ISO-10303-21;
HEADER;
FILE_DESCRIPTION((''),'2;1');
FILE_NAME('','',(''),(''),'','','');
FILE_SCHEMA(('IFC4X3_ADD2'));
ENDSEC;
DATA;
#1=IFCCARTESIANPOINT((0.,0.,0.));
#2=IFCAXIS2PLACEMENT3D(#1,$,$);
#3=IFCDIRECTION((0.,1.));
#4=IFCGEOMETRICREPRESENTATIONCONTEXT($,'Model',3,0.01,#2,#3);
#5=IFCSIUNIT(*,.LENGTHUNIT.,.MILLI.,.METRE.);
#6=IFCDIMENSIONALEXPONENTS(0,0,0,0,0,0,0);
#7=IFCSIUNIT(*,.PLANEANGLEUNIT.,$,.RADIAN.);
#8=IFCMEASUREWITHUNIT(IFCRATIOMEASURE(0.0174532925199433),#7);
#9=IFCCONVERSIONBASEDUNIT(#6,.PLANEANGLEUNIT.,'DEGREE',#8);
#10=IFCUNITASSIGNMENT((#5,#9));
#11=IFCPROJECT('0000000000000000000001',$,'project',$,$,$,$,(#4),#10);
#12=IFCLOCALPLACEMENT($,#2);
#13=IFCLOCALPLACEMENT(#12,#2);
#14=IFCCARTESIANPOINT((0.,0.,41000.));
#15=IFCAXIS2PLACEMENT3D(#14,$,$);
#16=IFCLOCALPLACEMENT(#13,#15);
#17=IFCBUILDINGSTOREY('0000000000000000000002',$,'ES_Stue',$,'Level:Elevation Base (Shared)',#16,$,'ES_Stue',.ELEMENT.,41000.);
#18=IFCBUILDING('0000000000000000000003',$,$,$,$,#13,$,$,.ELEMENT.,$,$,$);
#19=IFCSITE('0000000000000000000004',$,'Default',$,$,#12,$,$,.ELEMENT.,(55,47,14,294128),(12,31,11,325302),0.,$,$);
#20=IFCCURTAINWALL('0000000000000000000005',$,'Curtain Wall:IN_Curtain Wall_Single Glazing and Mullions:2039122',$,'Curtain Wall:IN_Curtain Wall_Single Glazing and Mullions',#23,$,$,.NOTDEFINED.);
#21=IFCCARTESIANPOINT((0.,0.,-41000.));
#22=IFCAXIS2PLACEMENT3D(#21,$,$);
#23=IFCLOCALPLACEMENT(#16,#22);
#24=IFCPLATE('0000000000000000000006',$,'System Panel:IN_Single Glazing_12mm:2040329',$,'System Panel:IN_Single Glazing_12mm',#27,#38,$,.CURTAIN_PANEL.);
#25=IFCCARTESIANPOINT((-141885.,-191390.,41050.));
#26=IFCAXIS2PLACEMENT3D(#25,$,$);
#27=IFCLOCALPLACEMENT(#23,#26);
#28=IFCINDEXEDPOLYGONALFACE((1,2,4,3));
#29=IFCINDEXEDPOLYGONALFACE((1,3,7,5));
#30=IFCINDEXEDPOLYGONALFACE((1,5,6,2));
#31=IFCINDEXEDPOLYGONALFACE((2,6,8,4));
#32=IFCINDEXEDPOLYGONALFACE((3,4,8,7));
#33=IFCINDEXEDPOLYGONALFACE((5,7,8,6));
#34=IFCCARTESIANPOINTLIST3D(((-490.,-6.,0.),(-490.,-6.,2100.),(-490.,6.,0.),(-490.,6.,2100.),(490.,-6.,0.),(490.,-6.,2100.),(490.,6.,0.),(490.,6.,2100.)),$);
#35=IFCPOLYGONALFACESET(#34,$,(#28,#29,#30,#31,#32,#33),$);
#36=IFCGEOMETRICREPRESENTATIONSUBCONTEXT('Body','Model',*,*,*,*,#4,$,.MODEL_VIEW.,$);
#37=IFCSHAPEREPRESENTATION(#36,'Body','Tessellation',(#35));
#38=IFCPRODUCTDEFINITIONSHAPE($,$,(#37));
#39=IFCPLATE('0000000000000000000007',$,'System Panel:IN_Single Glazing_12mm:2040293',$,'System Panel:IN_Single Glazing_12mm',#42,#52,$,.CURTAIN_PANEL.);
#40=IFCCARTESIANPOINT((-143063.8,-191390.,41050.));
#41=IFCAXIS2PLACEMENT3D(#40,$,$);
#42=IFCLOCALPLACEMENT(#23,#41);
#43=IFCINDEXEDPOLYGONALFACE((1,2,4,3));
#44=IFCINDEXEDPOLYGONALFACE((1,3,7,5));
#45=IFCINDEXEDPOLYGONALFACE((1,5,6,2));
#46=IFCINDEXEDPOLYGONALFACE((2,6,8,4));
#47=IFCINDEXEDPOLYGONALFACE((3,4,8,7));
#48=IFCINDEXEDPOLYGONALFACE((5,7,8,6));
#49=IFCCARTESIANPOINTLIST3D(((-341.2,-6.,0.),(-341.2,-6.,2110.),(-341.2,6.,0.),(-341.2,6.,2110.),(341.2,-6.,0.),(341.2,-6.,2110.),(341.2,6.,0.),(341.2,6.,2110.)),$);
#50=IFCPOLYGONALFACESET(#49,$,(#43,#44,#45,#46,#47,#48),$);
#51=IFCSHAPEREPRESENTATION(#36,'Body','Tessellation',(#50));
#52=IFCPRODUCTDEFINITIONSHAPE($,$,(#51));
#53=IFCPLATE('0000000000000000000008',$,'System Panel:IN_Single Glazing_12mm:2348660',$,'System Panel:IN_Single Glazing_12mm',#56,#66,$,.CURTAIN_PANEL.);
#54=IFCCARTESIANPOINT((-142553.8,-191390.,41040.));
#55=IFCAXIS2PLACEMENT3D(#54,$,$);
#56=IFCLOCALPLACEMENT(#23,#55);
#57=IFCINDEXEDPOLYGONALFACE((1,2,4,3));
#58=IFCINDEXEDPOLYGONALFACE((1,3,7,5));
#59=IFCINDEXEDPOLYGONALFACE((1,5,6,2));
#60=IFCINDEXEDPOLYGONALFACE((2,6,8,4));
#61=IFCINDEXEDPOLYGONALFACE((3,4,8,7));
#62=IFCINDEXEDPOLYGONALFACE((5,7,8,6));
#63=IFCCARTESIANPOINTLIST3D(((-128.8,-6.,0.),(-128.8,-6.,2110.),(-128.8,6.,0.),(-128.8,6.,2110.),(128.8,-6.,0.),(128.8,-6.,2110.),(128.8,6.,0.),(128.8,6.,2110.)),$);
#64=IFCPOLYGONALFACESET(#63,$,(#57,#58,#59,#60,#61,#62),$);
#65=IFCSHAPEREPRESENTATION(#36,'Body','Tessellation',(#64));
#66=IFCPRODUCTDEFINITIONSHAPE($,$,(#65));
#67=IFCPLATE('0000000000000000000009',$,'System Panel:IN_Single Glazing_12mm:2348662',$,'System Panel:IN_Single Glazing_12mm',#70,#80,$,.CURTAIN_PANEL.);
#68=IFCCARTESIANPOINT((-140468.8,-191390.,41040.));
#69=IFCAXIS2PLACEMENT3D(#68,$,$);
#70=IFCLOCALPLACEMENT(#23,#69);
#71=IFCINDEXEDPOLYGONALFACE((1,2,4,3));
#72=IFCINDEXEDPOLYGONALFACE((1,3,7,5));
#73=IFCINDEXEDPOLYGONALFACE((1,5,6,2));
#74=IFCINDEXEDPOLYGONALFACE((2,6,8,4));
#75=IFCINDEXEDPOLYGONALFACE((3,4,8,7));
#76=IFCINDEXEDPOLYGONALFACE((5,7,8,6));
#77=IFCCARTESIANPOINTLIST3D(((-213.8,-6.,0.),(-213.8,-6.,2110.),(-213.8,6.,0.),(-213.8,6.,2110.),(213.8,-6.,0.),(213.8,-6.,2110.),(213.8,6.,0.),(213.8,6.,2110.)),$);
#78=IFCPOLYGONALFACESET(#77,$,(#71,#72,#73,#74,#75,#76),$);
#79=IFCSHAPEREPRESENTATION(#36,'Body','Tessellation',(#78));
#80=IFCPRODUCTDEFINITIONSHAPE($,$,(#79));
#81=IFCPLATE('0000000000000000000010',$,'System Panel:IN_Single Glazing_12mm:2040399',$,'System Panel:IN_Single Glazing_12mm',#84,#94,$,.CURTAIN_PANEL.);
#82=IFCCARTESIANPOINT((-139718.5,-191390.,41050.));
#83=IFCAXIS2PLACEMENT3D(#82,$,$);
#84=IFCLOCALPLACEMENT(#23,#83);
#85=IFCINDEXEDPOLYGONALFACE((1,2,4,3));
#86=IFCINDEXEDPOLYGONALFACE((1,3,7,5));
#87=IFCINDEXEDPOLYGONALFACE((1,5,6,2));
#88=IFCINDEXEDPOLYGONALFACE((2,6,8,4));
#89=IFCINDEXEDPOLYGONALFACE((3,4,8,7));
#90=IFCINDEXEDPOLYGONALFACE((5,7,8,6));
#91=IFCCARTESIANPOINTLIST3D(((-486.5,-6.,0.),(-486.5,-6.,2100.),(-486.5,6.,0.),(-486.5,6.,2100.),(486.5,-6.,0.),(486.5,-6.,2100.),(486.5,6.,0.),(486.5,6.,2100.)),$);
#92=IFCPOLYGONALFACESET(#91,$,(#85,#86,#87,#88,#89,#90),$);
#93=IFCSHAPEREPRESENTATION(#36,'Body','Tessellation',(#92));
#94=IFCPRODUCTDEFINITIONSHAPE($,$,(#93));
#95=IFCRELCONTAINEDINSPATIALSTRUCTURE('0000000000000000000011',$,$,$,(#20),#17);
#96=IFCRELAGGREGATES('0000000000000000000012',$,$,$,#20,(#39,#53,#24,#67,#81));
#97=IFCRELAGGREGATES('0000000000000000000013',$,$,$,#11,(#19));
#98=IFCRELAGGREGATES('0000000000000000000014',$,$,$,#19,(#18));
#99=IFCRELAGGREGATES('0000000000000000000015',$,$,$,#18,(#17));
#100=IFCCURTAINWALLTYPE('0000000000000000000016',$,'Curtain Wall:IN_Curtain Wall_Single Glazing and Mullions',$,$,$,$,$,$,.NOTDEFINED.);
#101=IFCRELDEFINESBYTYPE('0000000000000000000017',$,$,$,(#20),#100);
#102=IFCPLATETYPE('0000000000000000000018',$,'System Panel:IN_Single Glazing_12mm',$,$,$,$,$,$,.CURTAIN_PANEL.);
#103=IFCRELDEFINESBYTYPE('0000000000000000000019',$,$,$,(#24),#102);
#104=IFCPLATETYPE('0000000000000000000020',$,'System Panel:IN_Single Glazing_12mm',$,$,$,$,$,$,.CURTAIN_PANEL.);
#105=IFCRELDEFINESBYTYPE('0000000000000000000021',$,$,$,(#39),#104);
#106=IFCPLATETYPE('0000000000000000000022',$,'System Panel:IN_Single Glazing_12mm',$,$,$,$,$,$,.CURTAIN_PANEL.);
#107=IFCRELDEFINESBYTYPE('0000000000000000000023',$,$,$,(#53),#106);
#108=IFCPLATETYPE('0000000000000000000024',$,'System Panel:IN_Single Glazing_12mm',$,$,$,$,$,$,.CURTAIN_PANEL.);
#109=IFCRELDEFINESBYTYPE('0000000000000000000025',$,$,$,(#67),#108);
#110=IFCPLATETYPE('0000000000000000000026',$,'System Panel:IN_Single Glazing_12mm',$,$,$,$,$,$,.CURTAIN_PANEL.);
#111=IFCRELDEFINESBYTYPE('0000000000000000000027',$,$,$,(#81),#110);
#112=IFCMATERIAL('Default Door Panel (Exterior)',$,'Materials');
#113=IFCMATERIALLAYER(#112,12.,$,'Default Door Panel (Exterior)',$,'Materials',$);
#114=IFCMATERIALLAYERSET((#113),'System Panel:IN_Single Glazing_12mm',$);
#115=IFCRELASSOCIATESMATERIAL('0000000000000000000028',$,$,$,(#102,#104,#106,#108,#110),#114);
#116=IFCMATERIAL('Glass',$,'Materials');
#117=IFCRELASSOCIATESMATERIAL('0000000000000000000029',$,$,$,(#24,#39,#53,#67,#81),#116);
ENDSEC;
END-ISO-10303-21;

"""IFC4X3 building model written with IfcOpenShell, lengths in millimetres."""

from ifc_helpers import new_model, entity, si_unit, converted_unit, direction, frame, origin, origin_2d_with_axis, place, context, subcontext, project, spatial, rectangle, extrude, source, transform, mapped, material, layer, layer_set, type_object, type_shapes, element, aggregate, save


model = new_model("IFC4X3")

# Units and contexts
model_context = context("Model", 3, precision=0.01, world=origin(), true_north=direction((0.0, 1.0)))
body_context = subcontext(model_context, "Body", "Model", "MODEL_VIEW")
ifc_project = project(units=[si_unit("LENGTHUNIT", "METRE", prefix="MILLI"), converted_unit("PLANEANGLEUNIT", "DEGREE", entity("IfcRatioMeasure", 0.0174532925199433), si_unit("PLANEANGLEUNIT", "RADIAN"), dimensions=[0, 0, 0, 0, 0, 0, 0])], contexts=[model_context])

# Site, building, storey
site_placement = place(None, origin())
site = spatial("IfcSite", under=ifc_project, at=site_placement, Name="Default", CompositionType="ELEMENT", RefLatitude=(55, 47, 14, 294128), RefLongitude=(12, 31, 11, 325302), RefElevation=0.0)
building_placement = place(site_placement, origin())
building = spatial("IfcBuilding", under=site, at=building_placement, CompositionType="ELEMENT")
storey_placement = place(building_placement, frame((0.0, 0.0, 41000.0)))
storey = spatial("IfcBuildingStorey", under=building, at=storey_placement, Name="ES_Stue", ObjectType="Level:Elevation Base (Shared)", LongName="ES_Stue", CompositionType="ELEMENT", Elevation=41000.0)

# Curtain wall, plates
curtain_wall_type_1 = type_object("IfcCurtainWallType", Name="Curtain Wall:IN_Curtain Wall_Single Glazing and Mullions", PredefinedType="NOTDEFINED")
curtain_wall_1_placement = place(storey_placement, frame((0.0, 0.0, -41000.0)))
curtain_wall_1 = element("IfcCurtainWall", 1, at=curtain_wall_1_placement, inside=storey, type_object=curtain_wall_type_1, Name="Curtain Wall:IN_Curtain Wall_Single Glazing and Mullions:2039122", ObjectType="Curtain Wall:IN_Curtain Wall_Single Glazing and Mullions", PredefinedType="NOTDEFINED")
ifc_material_1 = material(Name="Glass", Category="Materials")
ifc_material_2 = material(Name="Default Door Panel (Exterior)", Category="Materials")
ifc_layer_1 = layer(ifc_material_2, 12.0, Name="Default Door Panel (Exterior)", Category="Materials")
ifc_layer_set_1 = layer_set([ifc_layer_1], Name="System Panel:IN_Single Glazing_12mm")
plate_type_1 = type_object("IfcPlateType", Name="System Panel:IN_Single Glazing_12mm", PredefinedType="CURTAIN_PANEL", material=ifc_layer_set_1)
shared_shape_1 = source(origin(), body_context, "Body", "SweptSolid", [
    extrude(rectangle(XDim=12.0, YDim=980.0, at=origin_2d_with_axis()), frame((0.0, 0.0, 0.0), z_axis=(0.0, 0.0, 1.0), x_axis=(0.0, 1.0, 0.0)), (0.0, 0.0, 1.0), 2100.0),
])
type_shapes(plate_type_1, [shared_shape_1])
plate_1_placement = place(curtain_wall_1_placement, frame((-141885.0, -191390.0, 41050.0)))
plate_1 = element("IfcPlate", 2, at=plate_1_placement, type_object=plate_type_1, material=ifc_material_1, Name="System Panel:IN_Single Glazing_12mm:2040329", ObjectType="System Panel:IN_Single Glazing_12mm", PredefinedType="CURTAIN_PANEL", context=body_context, shape_type="MappedRepresentation", body=[
    mapped(shared_shape_1, transform((0.0, 0.0, 0.0), scale=1.0)),
])
plate_type_2 = type_object("IfcPlateType", Name="System Panel:IN_Single Glazing_12mm", PredefinedType="CURTAIN_PANEL", material=ifc_layer_set_1)
shared_shape_2 = source(origin(), body_context, "Body", "SweptSolid", [
    extrude(rectangle(XDim=12.0, YDim=682.5, at=origin_2d_with_axis()), frame((0.0, 0.0, 0.0), z_axis=(0.0, 0.0, 1.0), x_axis=(0.0, 1.0, 0.0)), (0.0, 0.0, 1.0), 2110.0),
])
type_shapes(plate_type_2, [shared_shape_2])
plate_2_placement = place(curtain_wall_1_placement, frame((-143063.8, -191390.0, 41050.0)))
plate_2 = element("IfcPlate", 3, at=plate_2_placement, type_object=plate_type_2, material=ifc_material_1, Name="System Panel:IN_Single Glazing_12mm:2040293", ObjectType="System Panel:IN_Single Glazing_12mm", PredefinedType="CURTAIN_PANEL", context=body_context, shape_type="MappedRepresentation", body=[
    mapped(shared_shape_2, transform((0.0, 0.0, 0.0), scale=1.0)),
])
plate_type_3 = type_object("IfcPlateType", Name="System Panel:IN_Single Glazing_12mm", PredefinedType="CURTAIN_PANEL", material=ifc_layer_set_1)
shared_shape_3 = source(origin(), body_context, "Body", "SweptSolid", [
    extrude(rectangle(XDim=12.0, YDim=257.5, at=origin_2d_with_axis()), frame((0.0, 0.0, 0.0), z_axis=(0.0, 0.0, 1.0), x_axis=(0.0, 1.0, 0.0)), (0.0, 0.0, 1.0), 2110.0),
])
type_shapes(plate_type_3, [shared_shape_3])
plate_3_placement = place(curtain_wall_1_placement, frame((-142553.8, -191390.0, 41040.0)))
plate_3 = element("IfcPlate", 4, at=plate_3_placement, type_object=plate_type_3, material=ifc_material_1, Name="System Panel:IN_Single Glazing_12mm:2348660", ObjectType="System Panel:IN_Single Glazing_12mm", PredefinedType="CURTAIN_PANEL", context=body_context, shape_type="MappedRepresentation", body=[
    mapped(shared_shape_3, transform((0.0, 0.0, 0.0), scale=1.0)),
])
plate_type_4 = type_object("IfcPlateType", Name="System Panel:IN_Single Glazing_12mm", PredefinedType="CURTAIN_PANEL", material=ifc_layer_set_1)
shared_shape_4 = source(origin(), body_context, "Body", "SweptSolid", [
    extrude(rectangle(XDim=12.0, YDim=427.5, at=origin_2d_with_axis()), frame((0.0, 0.0, 0.0), z_axis=(0.0, 0.0, 1.0), x_axis=(0.0, 1.0, 0.0)), (0.0, 0.0, 1.0), 2110.0),
])
type_shapes(plate_type_4, [shared_shape_4])
plate_4_placement = place(curtain_wall_1_placement, frame((-140468.8, -191390.0, 41040.0)))
plate_4 = element("IfcPlate", 5, at=plate_4_placement, type_object=plate_type_4, material=ifc_material_1, Name="System Panel:IN_Single Glazing_12mm:2348662", ObjectType="System Panel:IN_Single Glazing_12mm", PredefinedType="CURTAIN_PANEL", context=body_context, shape_type="MappedRepresentation", body=[
    mapped(shared_shape_4, transform((0.0, 0.0, 0.0), scale=1.0)),
])
plate_type_5 = type_object("IfcPlateType", Name="System Panel:IN_Single Glazing_12mm", PredefinedType="CURTAIN_PANEL", material=ifc_layer_set_1)
shared_shape_5 = source(origin(), body_context, "Body", "SweptSolid", [
    extrude(rectangle(XDim=12.0, YDim=973.0, at=origin_2d_with_axis()), frame((0.0, 0.0, 0.0), z_axis=(0.0, 0.0, 1.0), x_axis=(0.0, 1.0, 0.0)), (0.0, 0.0, 1.0), 2100.0),
])
type_shapes(plate_type_5, [shared_shape_5])
plate_5_placement = place(curtain_wall_1_placement, frame((-139718.5, -191390.0, 41050.0)))
plate_5 = element("IfcPlate", 6, at=plate_5_placement, type_object=plate_type_5, material=ifc_material_1, Name="System Panel:IN_Single Glazing_12mm:2040399", ObjectType="System Panel:IN_Single Glazing_12mm", PredefinedType="CURTAIN_PANEL", context=body_context, shape_type="MappedRepresentation", body=[
    mapped(shared_shape_5, transform((0.0, 0.0, 0.0), scale=1.0)),
])
aggregate(curtain_wall_1, [plate_2, plate_3, plate_1, plate_4, plate_5])

save(model, "model.ifc")
